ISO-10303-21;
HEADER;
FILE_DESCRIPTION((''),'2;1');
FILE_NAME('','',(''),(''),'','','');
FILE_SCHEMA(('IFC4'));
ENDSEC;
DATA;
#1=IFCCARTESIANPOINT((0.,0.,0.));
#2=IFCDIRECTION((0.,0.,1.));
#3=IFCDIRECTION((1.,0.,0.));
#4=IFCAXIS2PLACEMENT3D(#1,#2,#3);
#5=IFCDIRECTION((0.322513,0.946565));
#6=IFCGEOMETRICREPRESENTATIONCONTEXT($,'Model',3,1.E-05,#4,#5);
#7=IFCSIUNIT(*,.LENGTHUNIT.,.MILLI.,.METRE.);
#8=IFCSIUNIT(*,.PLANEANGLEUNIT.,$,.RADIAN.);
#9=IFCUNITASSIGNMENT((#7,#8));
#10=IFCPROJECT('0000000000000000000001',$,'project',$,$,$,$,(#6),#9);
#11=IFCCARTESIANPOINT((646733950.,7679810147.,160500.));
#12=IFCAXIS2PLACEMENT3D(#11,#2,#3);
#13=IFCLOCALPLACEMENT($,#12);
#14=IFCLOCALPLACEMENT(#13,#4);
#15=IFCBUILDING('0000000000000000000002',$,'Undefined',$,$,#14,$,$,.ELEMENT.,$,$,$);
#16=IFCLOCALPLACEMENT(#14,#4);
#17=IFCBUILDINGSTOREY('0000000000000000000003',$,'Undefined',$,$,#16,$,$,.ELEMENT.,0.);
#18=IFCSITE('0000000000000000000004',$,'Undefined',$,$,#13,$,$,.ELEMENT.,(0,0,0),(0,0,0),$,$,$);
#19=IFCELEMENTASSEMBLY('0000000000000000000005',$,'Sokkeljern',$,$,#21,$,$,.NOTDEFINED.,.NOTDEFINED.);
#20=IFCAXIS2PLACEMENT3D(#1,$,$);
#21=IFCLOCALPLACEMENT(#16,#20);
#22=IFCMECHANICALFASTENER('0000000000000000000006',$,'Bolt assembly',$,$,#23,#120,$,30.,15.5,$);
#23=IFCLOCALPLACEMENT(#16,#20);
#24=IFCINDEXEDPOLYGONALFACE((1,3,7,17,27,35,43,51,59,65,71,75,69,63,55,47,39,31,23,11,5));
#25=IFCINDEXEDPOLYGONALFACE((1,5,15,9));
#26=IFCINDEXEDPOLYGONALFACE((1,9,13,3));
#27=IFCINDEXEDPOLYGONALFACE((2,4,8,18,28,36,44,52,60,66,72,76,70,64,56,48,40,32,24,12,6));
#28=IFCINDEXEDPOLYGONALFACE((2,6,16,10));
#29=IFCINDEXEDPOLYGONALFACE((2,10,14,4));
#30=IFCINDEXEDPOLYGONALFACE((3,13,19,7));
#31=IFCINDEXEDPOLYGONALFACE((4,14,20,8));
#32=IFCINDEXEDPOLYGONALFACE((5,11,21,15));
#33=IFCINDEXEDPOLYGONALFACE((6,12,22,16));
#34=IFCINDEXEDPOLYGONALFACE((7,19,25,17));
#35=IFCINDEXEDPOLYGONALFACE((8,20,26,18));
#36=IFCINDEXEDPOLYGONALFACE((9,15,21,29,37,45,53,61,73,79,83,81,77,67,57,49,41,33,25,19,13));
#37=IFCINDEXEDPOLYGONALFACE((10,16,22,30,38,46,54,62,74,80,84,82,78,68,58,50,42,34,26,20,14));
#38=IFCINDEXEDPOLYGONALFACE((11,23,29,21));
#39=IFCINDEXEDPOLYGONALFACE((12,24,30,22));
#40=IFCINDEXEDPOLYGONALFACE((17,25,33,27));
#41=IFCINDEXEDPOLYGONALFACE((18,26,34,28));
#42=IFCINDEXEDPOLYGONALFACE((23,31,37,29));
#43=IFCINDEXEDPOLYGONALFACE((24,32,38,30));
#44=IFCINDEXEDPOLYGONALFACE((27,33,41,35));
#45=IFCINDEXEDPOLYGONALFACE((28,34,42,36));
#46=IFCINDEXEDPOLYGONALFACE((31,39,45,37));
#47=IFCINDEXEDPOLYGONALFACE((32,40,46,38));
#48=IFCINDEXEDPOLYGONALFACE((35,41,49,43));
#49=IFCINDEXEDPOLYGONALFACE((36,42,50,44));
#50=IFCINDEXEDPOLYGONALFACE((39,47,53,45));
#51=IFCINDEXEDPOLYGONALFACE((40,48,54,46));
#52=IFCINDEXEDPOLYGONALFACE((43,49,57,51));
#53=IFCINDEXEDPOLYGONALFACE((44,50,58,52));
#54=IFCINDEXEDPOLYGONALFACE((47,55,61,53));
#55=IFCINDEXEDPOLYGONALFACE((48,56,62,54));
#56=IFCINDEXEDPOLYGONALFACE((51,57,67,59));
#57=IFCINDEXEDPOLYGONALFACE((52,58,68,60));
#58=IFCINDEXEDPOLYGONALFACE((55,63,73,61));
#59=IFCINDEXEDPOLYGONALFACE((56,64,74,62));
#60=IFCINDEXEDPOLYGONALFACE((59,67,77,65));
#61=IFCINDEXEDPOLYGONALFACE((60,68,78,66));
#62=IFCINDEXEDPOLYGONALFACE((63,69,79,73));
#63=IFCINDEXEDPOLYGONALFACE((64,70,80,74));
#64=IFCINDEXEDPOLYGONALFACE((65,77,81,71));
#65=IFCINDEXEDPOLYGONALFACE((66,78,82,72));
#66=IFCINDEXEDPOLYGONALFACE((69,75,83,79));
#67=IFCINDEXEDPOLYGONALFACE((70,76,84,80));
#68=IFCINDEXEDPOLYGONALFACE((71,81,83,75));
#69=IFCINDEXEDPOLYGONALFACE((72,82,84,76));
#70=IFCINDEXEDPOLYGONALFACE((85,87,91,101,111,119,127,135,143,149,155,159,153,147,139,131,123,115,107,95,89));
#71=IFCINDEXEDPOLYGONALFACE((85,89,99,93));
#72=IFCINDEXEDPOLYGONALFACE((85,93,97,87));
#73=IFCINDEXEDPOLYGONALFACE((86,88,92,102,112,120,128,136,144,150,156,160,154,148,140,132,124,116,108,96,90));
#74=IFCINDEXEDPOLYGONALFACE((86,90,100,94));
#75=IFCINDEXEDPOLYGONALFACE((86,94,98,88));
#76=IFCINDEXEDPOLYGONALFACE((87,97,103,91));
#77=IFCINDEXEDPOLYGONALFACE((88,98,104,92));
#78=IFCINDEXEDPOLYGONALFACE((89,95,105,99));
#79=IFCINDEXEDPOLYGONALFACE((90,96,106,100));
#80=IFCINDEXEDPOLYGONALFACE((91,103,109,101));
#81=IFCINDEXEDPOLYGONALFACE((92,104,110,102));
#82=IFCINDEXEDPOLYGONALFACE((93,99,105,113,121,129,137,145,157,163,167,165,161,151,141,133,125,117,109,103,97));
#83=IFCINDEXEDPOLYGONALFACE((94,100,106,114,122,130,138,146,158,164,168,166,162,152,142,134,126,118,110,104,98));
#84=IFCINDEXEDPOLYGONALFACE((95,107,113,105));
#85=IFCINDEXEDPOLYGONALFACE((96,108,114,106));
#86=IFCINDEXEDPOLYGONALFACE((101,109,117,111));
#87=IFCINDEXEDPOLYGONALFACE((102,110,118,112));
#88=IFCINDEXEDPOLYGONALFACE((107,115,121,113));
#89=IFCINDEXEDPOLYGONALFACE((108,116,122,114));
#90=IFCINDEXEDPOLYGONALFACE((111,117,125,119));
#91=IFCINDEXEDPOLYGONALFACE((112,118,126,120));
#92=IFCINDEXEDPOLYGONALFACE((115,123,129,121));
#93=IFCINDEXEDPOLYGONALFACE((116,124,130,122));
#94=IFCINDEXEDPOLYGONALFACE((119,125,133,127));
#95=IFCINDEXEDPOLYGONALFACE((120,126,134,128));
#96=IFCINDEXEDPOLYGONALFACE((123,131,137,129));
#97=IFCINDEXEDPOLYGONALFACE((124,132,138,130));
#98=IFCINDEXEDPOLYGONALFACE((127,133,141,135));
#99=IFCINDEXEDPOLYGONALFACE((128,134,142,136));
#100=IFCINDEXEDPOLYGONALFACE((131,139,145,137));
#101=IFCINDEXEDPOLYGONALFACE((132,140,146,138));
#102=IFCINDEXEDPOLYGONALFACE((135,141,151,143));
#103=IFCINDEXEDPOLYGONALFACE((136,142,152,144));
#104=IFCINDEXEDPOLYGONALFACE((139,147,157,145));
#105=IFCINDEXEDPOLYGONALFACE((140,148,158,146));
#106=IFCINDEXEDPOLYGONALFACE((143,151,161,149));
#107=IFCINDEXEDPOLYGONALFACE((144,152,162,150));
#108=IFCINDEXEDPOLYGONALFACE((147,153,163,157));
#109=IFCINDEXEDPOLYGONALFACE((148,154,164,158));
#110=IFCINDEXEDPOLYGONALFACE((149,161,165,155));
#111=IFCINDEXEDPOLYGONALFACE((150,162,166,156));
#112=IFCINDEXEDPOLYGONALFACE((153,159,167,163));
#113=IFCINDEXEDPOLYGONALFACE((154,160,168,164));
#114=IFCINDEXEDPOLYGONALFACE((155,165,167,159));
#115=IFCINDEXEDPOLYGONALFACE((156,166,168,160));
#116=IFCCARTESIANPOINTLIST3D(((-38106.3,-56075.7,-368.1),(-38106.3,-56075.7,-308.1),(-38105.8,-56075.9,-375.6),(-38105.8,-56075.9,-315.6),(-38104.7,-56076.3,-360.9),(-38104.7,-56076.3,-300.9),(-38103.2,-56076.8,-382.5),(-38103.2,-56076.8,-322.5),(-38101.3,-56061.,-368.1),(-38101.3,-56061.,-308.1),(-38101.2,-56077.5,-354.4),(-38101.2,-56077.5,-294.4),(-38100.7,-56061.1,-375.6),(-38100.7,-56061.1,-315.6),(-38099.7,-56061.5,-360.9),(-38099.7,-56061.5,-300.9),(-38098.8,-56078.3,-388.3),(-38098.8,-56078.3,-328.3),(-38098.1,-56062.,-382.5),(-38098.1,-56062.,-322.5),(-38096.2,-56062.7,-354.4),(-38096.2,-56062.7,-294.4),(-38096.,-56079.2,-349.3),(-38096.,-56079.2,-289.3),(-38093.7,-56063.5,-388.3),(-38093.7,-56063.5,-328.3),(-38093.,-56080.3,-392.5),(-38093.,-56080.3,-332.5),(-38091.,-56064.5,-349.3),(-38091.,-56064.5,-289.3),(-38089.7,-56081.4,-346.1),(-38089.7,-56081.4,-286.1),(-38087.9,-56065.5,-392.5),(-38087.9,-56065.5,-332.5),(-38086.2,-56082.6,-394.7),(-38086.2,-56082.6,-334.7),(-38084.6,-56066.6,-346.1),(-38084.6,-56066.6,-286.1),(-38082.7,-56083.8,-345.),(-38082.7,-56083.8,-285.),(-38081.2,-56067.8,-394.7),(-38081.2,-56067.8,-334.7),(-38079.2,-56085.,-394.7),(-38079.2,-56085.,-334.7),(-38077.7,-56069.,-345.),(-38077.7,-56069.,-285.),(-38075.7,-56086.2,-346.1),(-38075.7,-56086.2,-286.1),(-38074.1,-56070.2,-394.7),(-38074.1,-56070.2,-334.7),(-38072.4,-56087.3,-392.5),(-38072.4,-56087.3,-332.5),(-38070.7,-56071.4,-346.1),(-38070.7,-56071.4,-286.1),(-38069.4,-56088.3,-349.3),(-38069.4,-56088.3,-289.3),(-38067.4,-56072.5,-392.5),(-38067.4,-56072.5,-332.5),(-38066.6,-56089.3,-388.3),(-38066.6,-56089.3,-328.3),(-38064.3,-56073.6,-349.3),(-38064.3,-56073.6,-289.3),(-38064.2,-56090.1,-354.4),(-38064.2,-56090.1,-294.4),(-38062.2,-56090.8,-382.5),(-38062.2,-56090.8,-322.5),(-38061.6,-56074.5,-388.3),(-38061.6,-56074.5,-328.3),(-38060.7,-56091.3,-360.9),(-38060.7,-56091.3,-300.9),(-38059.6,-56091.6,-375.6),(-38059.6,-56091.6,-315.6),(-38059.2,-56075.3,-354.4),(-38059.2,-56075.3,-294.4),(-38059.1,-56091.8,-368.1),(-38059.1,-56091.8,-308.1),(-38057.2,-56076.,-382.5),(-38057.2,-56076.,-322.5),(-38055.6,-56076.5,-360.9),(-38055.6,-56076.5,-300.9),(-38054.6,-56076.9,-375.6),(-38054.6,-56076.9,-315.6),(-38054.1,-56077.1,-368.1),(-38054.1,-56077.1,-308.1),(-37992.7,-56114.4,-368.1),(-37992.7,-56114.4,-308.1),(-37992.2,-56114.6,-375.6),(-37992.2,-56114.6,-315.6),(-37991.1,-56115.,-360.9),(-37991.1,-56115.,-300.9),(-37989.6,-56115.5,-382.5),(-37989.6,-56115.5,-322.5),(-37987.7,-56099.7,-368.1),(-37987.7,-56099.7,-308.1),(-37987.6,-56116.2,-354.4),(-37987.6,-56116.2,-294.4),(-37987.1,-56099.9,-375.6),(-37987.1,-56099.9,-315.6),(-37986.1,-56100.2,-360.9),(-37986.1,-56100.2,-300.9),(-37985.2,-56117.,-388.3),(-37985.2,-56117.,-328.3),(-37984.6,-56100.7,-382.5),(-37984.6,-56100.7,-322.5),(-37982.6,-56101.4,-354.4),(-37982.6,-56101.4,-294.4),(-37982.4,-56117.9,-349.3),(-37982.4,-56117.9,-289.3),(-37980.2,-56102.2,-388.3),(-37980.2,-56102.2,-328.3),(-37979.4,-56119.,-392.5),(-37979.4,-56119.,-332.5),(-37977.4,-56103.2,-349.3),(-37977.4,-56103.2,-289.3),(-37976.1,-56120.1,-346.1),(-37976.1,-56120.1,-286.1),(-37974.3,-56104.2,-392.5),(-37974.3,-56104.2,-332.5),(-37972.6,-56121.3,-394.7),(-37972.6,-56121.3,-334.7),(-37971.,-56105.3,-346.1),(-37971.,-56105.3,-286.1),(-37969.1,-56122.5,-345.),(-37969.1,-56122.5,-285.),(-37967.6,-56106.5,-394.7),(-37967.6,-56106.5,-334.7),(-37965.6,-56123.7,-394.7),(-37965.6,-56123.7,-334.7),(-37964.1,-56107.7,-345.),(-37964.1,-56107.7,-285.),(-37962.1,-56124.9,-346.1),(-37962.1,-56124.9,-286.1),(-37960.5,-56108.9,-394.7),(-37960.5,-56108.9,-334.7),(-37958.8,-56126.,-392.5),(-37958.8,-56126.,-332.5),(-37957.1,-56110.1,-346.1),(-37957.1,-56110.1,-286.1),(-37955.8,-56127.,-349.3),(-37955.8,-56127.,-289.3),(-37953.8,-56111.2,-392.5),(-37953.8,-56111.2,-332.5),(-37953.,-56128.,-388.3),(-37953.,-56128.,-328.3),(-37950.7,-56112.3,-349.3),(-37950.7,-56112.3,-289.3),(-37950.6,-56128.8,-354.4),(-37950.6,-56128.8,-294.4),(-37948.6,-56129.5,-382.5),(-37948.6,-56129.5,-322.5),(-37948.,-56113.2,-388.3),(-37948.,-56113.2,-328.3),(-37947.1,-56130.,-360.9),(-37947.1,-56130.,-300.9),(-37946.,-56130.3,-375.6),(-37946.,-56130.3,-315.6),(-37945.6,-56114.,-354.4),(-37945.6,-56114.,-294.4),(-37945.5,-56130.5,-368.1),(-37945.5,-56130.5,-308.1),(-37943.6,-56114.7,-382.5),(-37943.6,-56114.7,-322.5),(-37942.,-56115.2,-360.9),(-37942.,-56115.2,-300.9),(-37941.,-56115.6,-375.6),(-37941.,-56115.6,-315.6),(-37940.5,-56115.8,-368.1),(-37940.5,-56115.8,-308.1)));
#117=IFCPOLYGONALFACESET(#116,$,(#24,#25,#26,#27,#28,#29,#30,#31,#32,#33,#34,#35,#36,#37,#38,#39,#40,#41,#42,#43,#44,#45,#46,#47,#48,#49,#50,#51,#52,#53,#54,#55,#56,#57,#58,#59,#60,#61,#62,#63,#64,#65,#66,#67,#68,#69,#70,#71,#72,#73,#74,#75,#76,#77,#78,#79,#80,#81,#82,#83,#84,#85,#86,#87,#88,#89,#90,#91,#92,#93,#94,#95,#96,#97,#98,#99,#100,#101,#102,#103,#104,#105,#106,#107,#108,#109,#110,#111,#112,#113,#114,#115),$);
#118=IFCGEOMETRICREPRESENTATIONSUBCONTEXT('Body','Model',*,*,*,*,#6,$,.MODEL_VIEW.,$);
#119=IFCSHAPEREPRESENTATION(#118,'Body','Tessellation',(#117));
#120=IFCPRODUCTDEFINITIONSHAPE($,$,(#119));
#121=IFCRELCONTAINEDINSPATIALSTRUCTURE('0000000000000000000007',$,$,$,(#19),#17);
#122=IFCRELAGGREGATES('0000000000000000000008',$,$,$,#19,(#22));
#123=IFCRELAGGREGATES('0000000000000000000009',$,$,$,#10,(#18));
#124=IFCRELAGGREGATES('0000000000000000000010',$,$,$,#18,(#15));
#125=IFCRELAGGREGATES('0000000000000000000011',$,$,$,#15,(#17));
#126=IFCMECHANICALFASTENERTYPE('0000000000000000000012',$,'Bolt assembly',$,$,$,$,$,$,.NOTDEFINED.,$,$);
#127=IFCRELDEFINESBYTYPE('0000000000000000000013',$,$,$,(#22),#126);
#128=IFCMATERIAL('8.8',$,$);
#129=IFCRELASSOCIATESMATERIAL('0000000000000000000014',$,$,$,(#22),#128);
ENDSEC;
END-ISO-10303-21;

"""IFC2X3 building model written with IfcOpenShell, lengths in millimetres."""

from ifc_helpers import new_model, si_unit, direction, frame, origin_with_axes, origin_2d_with_axis, place, context, subcontext, project, spatial, circle, extrude, source, transform, mapped, material, type_object, element, aggregate, save


model = new_model("IFC2X3")

# Units and contexts
model_context = context("Model", 3, precision=1e-05, world=origin_with_axes(), true_north=direction((0.322513, 0.946565)))
body_context = subcontext(model_context, "Body", "Model", "MODEL_VIEW")
ifc_project = project(units=[si_unit("LENGTHUNIT", "METRE", prefix="MILLI"), si_unit("PLANEANGLEUNIT", "RADIAN")], contexts=[model_context])

# Site, building, storey
site_placement = place(None, frame((646733950.0, 7679810147.0, 160500.0), z_axis=(0.0, 0.0, 1.0), x_axis=(1.0, 0.0, 0.0)))
site = spatial("IfcSite", under=ifc_project, at=site_placement, Name="Undefined", CompositionType="ELEMENT", RefLatitude=(0, 0, 0), RefLongitude=(0, 0, 0))
building_placement = place(site_placement, origin_with_axes())
building = spatial("IfcBuilding", under=site, at=building_placement, Name="Undefined", CompositionType="ELEMENT")
storey_placement = place(building_placement, origin_with_axes())
storey = spatial("IfcBuildingStorey", under=building, at=storey_placement, Name="Undefined", CompositionType="ELEMENT", Elevation=0.0)

# Element assembly
assembly_1_placement = place(storey_placement, origin_with_axes())
assembly_1 = element("IfcElementAssembly", 1, at=assembly_1_placement, inside=storey, Name="Sokkeljern", AssemblyPlace="NOTDEFINED", PredefinedType="NOTDEFINED")

# Mechanical fastener
ifc_material_1 = material(Name="8.8")
mechanical_fastener_type = type_object("IfcMechanicalFastenerType", Name="Bolt assembly")
shared_shape_1 = source(origin_with_axes(), body_context, "Body", "SweptSolid", [
    extrude(circle(Radius=25.0, at=origin_2d_with_axis()), frame((0.0, -15.5, 0.0), z_axis=(0.0, 1.0, 0.0), x_axis=(1.0, 0.0, 0.0)), (0.0, 0.0, 1.0), 15.6),
])
mechanical_fastener_1_placement = place(assembly_1_placement, frame((-38025.9, -56103.0, -370.0), z_axis=(0.946565, -0.322513, 0.0), x_axis=(0.0, 0.0, 1.0)))
mechanical_fastener_1 = element("IfcMechanicalFastener", 2, at=mechanical_fastener_1_placement, type_object=mechanical_fastener_type, material=ifc_material_1, Name="Bolt assembly", NominalDiameter=30.0, NominalLength=15.5, context=body_context, shape_type="MappedRepresentation", body=[
    mapped(shared_shape_1, transform((0.0, 0.0, -60.0))),
    mapped(shared_shape_1, transform((60.0, 0.0, -60.0))),
    mapped(shared_shape_1, transform((0.0, 0.0, 60.0))),
    mapped(shared_shape_1, transform((60.0, 0.0, 60.0))),
])
aggregate(assembly_1, [mechanical_fastener_1])

save(model, "model.ifc")
